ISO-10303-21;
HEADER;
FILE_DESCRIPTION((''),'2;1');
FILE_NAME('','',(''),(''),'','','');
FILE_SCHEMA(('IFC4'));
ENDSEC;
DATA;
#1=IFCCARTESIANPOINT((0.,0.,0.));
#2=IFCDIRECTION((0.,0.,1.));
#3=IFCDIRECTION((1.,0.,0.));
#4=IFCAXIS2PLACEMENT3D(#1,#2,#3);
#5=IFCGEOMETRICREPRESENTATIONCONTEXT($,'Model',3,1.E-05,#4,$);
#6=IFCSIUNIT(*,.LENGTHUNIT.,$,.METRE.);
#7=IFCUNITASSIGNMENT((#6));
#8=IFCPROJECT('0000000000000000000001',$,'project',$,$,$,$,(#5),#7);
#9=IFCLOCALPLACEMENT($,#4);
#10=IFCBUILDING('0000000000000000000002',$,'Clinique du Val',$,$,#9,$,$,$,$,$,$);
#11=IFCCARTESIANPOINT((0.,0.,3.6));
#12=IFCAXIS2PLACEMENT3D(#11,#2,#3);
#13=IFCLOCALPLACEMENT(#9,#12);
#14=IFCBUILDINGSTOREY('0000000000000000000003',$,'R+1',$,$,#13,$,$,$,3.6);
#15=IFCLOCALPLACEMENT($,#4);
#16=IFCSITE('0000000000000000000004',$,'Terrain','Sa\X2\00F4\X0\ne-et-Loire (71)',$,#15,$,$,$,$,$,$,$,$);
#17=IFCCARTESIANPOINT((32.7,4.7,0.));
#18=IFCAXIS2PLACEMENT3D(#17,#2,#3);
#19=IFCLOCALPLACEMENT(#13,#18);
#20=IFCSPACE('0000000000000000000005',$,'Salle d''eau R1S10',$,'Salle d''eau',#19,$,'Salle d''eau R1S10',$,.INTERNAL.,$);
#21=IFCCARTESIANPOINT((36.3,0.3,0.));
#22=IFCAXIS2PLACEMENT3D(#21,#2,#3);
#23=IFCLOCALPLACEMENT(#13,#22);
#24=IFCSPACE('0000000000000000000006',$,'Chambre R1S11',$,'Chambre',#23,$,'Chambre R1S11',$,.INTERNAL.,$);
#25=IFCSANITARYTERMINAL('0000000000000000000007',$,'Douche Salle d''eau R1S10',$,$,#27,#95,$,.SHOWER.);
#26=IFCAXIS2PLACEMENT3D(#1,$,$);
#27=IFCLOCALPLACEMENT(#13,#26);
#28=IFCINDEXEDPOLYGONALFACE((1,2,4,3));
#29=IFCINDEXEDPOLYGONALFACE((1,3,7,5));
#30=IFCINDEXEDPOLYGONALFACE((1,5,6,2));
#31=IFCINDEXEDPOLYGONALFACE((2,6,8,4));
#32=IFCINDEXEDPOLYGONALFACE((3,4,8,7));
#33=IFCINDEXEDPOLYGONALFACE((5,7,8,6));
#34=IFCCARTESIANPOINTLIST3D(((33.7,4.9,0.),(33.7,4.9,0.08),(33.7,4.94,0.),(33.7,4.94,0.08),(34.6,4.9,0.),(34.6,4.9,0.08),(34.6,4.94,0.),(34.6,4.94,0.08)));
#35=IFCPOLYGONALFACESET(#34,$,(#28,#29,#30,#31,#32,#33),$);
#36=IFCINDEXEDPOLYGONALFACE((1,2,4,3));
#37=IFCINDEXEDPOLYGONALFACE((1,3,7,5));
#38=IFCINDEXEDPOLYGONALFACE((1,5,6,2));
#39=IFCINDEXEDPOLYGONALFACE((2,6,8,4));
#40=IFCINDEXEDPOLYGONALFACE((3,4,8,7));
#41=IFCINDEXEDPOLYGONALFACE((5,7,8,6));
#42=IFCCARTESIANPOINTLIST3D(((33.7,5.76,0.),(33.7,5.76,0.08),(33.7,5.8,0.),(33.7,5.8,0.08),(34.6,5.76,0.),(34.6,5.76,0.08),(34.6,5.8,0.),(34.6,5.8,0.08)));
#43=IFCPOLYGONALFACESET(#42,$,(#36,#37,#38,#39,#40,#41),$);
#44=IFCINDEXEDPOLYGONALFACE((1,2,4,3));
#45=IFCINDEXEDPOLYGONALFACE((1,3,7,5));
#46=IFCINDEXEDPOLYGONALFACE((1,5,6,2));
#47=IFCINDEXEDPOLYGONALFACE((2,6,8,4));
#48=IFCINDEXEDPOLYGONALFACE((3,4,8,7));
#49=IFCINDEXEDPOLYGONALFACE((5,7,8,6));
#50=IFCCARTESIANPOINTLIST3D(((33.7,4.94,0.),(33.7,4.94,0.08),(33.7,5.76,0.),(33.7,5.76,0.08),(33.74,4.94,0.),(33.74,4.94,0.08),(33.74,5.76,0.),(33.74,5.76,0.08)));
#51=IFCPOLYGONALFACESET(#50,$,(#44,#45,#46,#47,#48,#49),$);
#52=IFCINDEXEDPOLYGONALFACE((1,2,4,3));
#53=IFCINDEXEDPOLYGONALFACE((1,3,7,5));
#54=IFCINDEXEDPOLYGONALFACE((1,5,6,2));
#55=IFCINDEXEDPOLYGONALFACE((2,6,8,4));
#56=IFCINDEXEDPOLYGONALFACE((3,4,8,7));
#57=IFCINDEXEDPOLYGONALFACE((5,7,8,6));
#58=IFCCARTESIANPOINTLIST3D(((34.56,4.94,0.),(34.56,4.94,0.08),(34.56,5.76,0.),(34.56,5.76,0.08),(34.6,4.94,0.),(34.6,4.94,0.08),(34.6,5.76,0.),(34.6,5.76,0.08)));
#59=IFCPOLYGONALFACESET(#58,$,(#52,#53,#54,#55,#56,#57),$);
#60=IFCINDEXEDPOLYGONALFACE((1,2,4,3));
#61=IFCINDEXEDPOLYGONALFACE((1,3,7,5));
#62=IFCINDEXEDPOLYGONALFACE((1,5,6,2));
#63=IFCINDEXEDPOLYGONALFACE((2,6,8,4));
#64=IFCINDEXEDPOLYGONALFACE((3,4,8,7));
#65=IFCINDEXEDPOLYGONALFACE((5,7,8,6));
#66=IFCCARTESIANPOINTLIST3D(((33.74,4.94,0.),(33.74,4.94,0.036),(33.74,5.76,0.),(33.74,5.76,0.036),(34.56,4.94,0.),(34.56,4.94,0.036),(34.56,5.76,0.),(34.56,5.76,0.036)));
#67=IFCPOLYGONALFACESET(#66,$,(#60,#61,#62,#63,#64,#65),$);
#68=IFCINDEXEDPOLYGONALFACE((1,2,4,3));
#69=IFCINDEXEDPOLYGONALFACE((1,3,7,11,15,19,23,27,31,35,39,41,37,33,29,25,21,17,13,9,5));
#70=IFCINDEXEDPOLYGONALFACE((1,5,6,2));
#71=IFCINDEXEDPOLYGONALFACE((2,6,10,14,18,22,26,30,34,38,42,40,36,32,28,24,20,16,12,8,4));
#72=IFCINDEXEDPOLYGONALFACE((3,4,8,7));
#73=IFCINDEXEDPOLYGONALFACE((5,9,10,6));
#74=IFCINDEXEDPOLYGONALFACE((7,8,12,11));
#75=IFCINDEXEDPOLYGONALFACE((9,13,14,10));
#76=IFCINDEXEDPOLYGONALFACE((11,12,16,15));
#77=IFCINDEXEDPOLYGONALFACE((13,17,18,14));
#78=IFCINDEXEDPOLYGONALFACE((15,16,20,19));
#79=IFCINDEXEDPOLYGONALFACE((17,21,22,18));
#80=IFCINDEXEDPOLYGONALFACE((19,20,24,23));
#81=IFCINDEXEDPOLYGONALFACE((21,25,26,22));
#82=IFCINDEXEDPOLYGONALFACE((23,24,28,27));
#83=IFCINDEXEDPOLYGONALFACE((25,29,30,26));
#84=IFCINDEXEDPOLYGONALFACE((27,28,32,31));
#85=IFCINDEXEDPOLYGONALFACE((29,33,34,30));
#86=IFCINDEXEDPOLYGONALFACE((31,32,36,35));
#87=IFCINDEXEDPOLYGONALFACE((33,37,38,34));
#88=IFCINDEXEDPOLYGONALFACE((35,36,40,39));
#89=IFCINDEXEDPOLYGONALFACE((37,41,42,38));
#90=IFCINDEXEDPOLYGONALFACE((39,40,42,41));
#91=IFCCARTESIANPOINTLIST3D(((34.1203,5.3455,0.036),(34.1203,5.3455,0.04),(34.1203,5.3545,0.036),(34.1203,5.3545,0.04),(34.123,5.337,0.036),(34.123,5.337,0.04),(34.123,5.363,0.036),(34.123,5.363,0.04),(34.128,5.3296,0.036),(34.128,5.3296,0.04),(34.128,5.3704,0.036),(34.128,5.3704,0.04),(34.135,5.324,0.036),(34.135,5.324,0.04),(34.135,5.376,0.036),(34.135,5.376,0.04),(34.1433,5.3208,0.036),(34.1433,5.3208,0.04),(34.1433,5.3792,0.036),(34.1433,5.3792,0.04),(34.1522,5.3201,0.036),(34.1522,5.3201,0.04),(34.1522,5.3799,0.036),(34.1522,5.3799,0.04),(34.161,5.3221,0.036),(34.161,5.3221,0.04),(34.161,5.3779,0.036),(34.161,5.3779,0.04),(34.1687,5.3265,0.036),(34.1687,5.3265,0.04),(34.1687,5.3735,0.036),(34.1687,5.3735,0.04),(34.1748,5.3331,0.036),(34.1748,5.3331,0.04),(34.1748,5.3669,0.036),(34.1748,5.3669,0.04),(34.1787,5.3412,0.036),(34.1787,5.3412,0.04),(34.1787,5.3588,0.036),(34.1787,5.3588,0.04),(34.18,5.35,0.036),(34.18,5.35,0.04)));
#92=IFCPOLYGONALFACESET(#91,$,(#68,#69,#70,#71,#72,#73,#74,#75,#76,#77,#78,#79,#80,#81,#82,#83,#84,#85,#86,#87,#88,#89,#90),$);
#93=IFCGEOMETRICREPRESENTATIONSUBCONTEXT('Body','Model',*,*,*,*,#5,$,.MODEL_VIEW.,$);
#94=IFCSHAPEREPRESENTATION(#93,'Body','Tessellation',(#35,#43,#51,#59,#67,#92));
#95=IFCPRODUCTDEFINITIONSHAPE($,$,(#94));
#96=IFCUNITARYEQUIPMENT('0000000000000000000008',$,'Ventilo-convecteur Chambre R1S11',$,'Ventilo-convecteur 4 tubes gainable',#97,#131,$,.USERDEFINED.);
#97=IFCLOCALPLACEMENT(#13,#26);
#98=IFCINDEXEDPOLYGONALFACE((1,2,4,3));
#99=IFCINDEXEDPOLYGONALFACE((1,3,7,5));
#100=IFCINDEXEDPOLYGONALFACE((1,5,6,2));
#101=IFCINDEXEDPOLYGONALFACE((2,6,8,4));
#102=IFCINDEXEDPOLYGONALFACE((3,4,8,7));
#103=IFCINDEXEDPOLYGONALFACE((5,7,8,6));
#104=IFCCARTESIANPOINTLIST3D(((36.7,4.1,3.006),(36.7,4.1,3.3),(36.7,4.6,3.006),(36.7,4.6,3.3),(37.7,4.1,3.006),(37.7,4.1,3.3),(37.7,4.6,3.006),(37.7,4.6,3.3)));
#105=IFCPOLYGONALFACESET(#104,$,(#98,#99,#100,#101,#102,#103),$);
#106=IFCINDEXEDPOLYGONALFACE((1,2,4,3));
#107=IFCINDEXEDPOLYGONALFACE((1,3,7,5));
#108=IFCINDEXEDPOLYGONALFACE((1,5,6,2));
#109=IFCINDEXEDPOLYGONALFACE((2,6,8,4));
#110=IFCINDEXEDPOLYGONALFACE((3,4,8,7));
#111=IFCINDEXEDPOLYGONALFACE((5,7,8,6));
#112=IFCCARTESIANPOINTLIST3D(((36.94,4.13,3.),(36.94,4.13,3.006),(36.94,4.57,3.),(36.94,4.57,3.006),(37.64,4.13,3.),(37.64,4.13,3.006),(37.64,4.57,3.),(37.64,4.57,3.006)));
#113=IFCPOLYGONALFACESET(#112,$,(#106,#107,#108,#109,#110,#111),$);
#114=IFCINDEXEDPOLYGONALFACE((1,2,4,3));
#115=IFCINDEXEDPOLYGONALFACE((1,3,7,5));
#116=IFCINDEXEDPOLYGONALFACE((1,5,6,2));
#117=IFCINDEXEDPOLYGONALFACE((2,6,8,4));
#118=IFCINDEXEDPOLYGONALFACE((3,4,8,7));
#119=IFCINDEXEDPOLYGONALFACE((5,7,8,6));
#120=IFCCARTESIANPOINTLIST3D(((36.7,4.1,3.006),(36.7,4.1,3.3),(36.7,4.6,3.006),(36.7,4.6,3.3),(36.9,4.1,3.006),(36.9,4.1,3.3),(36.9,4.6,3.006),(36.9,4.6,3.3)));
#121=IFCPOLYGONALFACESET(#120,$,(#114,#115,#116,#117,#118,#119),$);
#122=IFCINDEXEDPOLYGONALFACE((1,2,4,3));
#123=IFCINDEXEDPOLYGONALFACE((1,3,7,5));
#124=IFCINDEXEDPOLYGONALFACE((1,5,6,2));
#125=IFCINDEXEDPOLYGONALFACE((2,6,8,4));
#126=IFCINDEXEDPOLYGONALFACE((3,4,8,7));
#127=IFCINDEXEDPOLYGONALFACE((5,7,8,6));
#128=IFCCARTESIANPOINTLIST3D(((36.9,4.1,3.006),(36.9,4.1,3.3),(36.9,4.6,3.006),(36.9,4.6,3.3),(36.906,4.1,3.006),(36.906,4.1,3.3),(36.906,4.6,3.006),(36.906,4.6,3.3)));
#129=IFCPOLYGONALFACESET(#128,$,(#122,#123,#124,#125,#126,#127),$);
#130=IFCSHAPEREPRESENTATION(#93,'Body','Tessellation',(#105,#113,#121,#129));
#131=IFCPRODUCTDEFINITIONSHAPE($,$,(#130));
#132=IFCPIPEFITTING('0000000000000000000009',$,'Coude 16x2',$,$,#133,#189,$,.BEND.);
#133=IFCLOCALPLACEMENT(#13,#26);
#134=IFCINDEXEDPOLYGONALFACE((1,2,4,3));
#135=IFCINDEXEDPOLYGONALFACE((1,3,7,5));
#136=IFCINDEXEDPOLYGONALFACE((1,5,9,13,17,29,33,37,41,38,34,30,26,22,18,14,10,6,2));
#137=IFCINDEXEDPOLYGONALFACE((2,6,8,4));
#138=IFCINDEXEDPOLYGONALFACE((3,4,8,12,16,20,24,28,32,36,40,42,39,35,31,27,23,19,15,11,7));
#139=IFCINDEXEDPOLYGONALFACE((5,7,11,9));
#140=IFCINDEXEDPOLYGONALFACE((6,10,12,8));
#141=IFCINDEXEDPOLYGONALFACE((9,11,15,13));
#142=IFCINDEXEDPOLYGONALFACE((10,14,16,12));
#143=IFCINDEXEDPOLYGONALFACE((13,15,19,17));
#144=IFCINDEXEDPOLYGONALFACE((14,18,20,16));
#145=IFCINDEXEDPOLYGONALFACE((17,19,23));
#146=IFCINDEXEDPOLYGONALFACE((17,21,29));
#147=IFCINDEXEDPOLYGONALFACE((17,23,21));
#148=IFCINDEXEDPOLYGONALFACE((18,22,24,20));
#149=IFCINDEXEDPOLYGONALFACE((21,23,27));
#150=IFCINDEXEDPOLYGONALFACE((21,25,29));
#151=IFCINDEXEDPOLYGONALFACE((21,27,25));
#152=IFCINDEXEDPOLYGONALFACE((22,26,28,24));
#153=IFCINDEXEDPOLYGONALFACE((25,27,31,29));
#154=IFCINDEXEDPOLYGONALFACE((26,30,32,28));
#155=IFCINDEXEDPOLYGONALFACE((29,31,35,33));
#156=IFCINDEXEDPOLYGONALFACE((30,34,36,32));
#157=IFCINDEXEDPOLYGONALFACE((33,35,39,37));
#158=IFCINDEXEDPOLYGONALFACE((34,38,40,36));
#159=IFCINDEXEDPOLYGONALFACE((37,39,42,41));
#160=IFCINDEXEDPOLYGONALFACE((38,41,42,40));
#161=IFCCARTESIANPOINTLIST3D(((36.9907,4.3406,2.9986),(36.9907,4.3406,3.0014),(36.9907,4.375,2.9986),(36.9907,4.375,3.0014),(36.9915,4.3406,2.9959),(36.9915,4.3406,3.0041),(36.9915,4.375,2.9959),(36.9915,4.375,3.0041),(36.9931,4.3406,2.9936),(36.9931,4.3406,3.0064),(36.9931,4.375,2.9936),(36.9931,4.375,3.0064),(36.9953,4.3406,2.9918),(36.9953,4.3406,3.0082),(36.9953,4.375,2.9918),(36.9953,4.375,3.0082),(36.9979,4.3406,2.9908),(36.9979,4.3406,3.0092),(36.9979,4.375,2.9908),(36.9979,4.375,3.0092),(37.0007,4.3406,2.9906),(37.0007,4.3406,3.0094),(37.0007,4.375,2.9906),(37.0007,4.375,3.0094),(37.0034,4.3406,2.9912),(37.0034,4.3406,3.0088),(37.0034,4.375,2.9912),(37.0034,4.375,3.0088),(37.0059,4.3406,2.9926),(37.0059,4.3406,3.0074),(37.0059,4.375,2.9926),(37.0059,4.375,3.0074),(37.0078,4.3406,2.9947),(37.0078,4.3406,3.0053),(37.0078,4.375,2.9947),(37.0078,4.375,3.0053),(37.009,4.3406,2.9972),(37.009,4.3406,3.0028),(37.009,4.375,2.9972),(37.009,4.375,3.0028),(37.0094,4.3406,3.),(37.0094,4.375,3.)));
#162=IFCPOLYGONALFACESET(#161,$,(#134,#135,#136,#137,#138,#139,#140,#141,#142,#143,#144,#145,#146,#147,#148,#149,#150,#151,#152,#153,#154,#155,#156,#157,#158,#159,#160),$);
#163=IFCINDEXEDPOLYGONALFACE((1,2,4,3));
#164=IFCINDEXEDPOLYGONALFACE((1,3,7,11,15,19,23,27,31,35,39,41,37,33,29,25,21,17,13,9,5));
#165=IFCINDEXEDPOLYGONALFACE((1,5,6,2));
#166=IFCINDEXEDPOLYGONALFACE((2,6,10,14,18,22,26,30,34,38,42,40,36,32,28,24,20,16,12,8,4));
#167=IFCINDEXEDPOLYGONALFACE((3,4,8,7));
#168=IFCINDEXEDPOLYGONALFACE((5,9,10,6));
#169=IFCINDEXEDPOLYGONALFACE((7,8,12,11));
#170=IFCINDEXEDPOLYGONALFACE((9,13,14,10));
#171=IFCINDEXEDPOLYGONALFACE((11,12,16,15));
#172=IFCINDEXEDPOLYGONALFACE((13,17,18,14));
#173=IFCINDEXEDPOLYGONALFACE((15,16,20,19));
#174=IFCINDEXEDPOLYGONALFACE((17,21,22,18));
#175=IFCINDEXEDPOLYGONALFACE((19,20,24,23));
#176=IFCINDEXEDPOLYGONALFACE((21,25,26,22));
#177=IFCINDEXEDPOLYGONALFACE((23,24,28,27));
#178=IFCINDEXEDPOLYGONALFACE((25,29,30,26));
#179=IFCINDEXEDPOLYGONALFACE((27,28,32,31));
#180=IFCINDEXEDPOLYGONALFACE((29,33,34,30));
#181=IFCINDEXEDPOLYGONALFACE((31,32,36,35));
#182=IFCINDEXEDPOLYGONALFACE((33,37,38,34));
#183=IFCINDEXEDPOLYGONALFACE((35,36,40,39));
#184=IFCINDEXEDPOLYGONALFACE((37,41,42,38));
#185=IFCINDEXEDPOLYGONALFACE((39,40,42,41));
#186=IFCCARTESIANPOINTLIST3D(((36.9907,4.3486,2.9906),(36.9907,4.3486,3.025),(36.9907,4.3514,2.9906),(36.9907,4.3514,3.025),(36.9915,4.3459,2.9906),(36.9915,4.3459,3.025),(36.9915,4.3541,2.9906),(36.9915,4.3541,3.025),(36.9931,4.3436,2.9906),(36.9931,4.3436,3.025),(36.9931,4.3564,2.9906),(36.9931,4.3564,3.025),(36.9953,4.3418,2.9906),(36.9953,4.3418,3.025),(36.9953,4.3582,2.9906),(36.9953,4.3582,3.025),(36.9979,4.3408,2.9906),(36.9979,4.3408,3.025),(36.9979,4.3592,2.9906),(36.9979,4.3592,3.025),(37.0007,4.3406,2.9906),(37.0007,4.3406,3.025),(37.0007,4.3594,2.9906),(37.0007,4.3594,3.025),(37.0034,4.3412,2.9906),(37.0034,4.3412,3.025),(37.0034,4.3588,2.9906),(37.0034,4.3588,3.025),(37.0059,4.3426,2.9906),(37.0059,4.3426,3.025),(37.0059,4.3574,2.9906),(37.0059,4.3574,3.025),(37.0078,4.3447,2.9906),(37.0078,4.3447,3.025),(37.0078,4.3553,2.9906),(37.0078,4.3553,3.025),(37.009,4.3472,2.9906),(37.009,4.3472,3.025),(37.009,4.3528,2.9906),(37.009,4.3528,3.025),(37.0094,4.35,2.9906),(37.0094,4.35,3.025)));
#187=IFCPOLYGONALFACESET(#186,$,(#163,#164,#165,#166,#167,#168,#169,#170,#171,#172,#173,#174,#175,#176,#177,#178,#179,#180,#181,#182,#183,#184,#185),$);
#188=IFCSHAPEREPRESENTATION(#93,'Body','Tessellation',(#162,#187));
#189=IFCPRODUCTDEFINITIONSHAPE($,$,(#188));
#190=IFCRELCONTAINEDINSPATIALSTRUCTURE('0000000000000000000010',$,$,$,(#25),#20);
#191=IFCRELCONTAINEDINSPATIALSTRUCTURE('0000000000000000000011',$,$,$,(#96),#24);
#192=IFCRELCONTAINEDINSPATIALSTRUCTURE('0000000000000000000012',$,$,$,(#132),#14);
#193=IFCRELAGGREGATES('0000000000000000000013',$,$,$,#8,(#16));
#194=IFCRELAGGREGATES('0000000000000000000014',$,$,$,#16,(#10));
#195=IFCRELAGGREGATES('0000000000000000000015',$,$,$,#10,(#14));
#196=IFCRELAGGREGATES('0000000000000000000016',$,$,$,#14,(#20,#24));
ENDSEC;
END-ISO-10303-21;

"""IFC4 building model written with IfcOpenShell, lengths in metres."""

from ifc_helpers import new_model, si_unit, frame, frame_2d, origin_with_axes, place, context, subcontext, project, spatial, rectangle, circle, extrude, element, save


model = new_model("IFC4")

# Units and contexts
model_context = context("Model", 3, precision=1e-05, world=origin_with_axes())
body_context = subcontext(model_context, "Body", "Model", "MODEL_VIEW")
ifc_project = project(units=[si_unit("LENGTHUNIT", "METRE")], contexts=[model_context])

# Site, building, storey
site_placement = place(None, origin_with_axes())
site = spatial("IfcSite", under=ifc_project, at=site_placement, Name="Terrain", Description="Saône-et-Loire (71)")
building_placement = place(None, origin_with_axes())
building = spatial("IfcBuilding", under=site, at=building_placement, Name="Clinique du Val")
storey_placement = place(building_placement, frame((0.0, 0.0, 3.6), z_axis=(0.0, 0.0, 1.0), x_axis=(1.0, 0.0, 0.0)))
storey = spatial("IfcBuildingStorey", under=building, at=storey_placement, Name="R+1", Elevation=3.6)

# Shared definitions
space_1_placement = place(storey_placement, frame((32.7, 4.7, 0.0), z_axis=(0.0, 0.0, 1.0), x_axis=(1.0, 0.0, 0.0)))
space_1 = spatial("IfcSpace", under=storey, at=space_1_placement, Name="Salle d'eau R1S10", ObjectType="Salle d'eau", LongName="Salle d'eau R1S10", PredefinedType="INTERNAL")

# Sanitary terminal
sanitary_terminal_1_placement = place(space_1_placement, frame((1.0, 0.2, 0.0), z_axis=(0.0, 0.0, 1.0), x_axis=(1.0, 0.0, 0.0)))
element("IfcSanitaryTerminal", 1, at=sanitary_terminal_1_placement, inside=space_1, Name="Douche Salle d'eau R1S10", PredefinedType="SHOWER", context=body_context, shape_type="SweptSolid", body=[
    extrude(rectangle(XDim=0.9, YDim=0.04, at=frame_2d((0.45, 0.02))), origin_with_axes(), (0.0, 0.0, 1.0), 0.08),
    extrude(rectangle(XDim=0.9, YDim=0.04, at=frame_2d((0.45, 0.02))), frame((0.0, 0.86, 0.0), z_axis=(0.0, 0.0, 1.0), x_axis=(1.0, 0.0, 0.0)), (0.0, 0.0, 1.0), 0.08),
    extrude(rectangle(XDim=0.04, YDim=0.82, at=frame_2d((0.02, 0.41))), frame((0.0, 0.04, 0.0), z_axis=(0.0, 0.0, 1.0), x_axis=(1.0, 0.0, 0.0)), (0.0, 0.0, 1.0), 0.08),
    extrude(rectangle(XDim=0.04, YDim=0.82, at=frame_2d((0.02, 0.41))), frame((0.86, 0.04, 0.0), z_axis=(0.0, 0.0, 1.0), x_axis=(1.0, 0.0, 0.0)), (0.0, 0.0, 1.0), 0.08),
    extrude(rectangle(XDim=0.82, YDim=0.82, at=frame_2d((0.41, 0.41))), frame((0.04, 0.04, 0.0), z_axis=(0.0, 0.0, 1.0), x_axis=(1.0, 0.0, 0.0)), (0.0, 0.0, 1.0), 0.036),
    extrude(circle(Radius=0.03), frame((0.45, 0.45, 0.036), z_axis=(0.0, 0.0, 1.0), x_axis=(1.0, 0.0, 0.0)), (0.0, 0.0, 1.0), 0.004),
])

# Shared definitions
space_2_placement = place(storey_placement, frame((36.3, 0.3, 0.0), z_axis=(0.0, 0.0, 1.0), x_axis=(1.0, 0.0, 0.0)))
space_2 = spatial("IfcSpace", under=storey, at=space_2_placement, Name="Chambre R1S11", ObjectType="Chambre", LongName="Chambre R1S11", PredefinedType="INTERNAL")

# Unitary equipment
unitary_equipment_placement = place(space_2_placement, frame((0.4, 3.8, 3.0), z_axis=(0.0, 0.0, 1.0), x_axis=(1.0, 0.0, 0.0)))
element("IfcUnitaryEquipment", 2, at=unitary_equipment_placement, inside=space_2, Name="Ventilo-convecteur Chambre R1S11", ObjectType="Ventilo-convecteur 4 tubes gainable", PredefinedType="USERDEFINED", context=body_context, shape_type="SweptSolid", body=[
    extrude(rectangle(XDim=1.0, YDim=0.5, at=frame_2d((0.5, 0.25))), frame((0.0, 0.0, 0.006), z_axis=(0.0, 0.0, 1.0), x_axis=(1.0, 0.0, 0.0)), (0.0, 0.0, 1.0), 0.294),
    extrude(rectangle(XDim=0.7, YDim=0.44, at=frame_2d((0.35, 0.22))), frame((0.24, 0.03, 0.0), z_axis=(0.0, 0.0, 1.0), x_axis=(1.0, 0.0, 0.0)), (0.0, 0.0, 1.0), 0.006),
    extrude(rectangle(XDim=0.2, YDim=0.5, at=frame_2d((0.1, 0.25))), frame((0.0, 0.0, 0.006), z_axis=(0.0, 0.0, 1.0), x_axis=(1.0, 0.0, 0.0)), (0.0, 0.0, 1.0), 0.294),
    extrude(rectangle(XDim=0.006, YDim=0.5, at=frame_2d((0.003, 0.25))), frame((0.2, 0.0, 0.006), z_axis=(0.0, 0.0, 1.0), x_axis=(1.0, 0.0, 0.0)), (0.0, 0.0, 1.0), 0.294),
])

# Pipe fitting
for number, where, z_axis, x_axis, name in (
    (3, (37.0, 4.35, 3.0), (0.0, 0.0, 1.0), (1.0, 0.0, 0.0), "Coude 16x2"),
):
    element("IfcPipeFitting", number, at=place(storey_placement, frame(where, z_axis=z_axis, x_axis=x_axis)), inside=storey, Name=name, PredefinedType="BEND", context=body_context, shape_type="SweptSolid", body=[
        extrude(circle(Radius=0.0094), frame((0.0, -0.0094, 0.0), z_axis=(0.0, 1.0, 0.0), x_axis=(1.0, 0.0, 0.0)), (0.0, 0.0, 1.0), 0.0344),
        extrude(circle(Radius=0.0094), frame((0.0, 0.0, -0.0094), z_axis=(0.0, 0.0, 1.0), x_axis=(1.0, 0.0, 0.0)), (0.0, 0.0, 1.0), 0.0344),
    ])

save(model, "model.ifc")
